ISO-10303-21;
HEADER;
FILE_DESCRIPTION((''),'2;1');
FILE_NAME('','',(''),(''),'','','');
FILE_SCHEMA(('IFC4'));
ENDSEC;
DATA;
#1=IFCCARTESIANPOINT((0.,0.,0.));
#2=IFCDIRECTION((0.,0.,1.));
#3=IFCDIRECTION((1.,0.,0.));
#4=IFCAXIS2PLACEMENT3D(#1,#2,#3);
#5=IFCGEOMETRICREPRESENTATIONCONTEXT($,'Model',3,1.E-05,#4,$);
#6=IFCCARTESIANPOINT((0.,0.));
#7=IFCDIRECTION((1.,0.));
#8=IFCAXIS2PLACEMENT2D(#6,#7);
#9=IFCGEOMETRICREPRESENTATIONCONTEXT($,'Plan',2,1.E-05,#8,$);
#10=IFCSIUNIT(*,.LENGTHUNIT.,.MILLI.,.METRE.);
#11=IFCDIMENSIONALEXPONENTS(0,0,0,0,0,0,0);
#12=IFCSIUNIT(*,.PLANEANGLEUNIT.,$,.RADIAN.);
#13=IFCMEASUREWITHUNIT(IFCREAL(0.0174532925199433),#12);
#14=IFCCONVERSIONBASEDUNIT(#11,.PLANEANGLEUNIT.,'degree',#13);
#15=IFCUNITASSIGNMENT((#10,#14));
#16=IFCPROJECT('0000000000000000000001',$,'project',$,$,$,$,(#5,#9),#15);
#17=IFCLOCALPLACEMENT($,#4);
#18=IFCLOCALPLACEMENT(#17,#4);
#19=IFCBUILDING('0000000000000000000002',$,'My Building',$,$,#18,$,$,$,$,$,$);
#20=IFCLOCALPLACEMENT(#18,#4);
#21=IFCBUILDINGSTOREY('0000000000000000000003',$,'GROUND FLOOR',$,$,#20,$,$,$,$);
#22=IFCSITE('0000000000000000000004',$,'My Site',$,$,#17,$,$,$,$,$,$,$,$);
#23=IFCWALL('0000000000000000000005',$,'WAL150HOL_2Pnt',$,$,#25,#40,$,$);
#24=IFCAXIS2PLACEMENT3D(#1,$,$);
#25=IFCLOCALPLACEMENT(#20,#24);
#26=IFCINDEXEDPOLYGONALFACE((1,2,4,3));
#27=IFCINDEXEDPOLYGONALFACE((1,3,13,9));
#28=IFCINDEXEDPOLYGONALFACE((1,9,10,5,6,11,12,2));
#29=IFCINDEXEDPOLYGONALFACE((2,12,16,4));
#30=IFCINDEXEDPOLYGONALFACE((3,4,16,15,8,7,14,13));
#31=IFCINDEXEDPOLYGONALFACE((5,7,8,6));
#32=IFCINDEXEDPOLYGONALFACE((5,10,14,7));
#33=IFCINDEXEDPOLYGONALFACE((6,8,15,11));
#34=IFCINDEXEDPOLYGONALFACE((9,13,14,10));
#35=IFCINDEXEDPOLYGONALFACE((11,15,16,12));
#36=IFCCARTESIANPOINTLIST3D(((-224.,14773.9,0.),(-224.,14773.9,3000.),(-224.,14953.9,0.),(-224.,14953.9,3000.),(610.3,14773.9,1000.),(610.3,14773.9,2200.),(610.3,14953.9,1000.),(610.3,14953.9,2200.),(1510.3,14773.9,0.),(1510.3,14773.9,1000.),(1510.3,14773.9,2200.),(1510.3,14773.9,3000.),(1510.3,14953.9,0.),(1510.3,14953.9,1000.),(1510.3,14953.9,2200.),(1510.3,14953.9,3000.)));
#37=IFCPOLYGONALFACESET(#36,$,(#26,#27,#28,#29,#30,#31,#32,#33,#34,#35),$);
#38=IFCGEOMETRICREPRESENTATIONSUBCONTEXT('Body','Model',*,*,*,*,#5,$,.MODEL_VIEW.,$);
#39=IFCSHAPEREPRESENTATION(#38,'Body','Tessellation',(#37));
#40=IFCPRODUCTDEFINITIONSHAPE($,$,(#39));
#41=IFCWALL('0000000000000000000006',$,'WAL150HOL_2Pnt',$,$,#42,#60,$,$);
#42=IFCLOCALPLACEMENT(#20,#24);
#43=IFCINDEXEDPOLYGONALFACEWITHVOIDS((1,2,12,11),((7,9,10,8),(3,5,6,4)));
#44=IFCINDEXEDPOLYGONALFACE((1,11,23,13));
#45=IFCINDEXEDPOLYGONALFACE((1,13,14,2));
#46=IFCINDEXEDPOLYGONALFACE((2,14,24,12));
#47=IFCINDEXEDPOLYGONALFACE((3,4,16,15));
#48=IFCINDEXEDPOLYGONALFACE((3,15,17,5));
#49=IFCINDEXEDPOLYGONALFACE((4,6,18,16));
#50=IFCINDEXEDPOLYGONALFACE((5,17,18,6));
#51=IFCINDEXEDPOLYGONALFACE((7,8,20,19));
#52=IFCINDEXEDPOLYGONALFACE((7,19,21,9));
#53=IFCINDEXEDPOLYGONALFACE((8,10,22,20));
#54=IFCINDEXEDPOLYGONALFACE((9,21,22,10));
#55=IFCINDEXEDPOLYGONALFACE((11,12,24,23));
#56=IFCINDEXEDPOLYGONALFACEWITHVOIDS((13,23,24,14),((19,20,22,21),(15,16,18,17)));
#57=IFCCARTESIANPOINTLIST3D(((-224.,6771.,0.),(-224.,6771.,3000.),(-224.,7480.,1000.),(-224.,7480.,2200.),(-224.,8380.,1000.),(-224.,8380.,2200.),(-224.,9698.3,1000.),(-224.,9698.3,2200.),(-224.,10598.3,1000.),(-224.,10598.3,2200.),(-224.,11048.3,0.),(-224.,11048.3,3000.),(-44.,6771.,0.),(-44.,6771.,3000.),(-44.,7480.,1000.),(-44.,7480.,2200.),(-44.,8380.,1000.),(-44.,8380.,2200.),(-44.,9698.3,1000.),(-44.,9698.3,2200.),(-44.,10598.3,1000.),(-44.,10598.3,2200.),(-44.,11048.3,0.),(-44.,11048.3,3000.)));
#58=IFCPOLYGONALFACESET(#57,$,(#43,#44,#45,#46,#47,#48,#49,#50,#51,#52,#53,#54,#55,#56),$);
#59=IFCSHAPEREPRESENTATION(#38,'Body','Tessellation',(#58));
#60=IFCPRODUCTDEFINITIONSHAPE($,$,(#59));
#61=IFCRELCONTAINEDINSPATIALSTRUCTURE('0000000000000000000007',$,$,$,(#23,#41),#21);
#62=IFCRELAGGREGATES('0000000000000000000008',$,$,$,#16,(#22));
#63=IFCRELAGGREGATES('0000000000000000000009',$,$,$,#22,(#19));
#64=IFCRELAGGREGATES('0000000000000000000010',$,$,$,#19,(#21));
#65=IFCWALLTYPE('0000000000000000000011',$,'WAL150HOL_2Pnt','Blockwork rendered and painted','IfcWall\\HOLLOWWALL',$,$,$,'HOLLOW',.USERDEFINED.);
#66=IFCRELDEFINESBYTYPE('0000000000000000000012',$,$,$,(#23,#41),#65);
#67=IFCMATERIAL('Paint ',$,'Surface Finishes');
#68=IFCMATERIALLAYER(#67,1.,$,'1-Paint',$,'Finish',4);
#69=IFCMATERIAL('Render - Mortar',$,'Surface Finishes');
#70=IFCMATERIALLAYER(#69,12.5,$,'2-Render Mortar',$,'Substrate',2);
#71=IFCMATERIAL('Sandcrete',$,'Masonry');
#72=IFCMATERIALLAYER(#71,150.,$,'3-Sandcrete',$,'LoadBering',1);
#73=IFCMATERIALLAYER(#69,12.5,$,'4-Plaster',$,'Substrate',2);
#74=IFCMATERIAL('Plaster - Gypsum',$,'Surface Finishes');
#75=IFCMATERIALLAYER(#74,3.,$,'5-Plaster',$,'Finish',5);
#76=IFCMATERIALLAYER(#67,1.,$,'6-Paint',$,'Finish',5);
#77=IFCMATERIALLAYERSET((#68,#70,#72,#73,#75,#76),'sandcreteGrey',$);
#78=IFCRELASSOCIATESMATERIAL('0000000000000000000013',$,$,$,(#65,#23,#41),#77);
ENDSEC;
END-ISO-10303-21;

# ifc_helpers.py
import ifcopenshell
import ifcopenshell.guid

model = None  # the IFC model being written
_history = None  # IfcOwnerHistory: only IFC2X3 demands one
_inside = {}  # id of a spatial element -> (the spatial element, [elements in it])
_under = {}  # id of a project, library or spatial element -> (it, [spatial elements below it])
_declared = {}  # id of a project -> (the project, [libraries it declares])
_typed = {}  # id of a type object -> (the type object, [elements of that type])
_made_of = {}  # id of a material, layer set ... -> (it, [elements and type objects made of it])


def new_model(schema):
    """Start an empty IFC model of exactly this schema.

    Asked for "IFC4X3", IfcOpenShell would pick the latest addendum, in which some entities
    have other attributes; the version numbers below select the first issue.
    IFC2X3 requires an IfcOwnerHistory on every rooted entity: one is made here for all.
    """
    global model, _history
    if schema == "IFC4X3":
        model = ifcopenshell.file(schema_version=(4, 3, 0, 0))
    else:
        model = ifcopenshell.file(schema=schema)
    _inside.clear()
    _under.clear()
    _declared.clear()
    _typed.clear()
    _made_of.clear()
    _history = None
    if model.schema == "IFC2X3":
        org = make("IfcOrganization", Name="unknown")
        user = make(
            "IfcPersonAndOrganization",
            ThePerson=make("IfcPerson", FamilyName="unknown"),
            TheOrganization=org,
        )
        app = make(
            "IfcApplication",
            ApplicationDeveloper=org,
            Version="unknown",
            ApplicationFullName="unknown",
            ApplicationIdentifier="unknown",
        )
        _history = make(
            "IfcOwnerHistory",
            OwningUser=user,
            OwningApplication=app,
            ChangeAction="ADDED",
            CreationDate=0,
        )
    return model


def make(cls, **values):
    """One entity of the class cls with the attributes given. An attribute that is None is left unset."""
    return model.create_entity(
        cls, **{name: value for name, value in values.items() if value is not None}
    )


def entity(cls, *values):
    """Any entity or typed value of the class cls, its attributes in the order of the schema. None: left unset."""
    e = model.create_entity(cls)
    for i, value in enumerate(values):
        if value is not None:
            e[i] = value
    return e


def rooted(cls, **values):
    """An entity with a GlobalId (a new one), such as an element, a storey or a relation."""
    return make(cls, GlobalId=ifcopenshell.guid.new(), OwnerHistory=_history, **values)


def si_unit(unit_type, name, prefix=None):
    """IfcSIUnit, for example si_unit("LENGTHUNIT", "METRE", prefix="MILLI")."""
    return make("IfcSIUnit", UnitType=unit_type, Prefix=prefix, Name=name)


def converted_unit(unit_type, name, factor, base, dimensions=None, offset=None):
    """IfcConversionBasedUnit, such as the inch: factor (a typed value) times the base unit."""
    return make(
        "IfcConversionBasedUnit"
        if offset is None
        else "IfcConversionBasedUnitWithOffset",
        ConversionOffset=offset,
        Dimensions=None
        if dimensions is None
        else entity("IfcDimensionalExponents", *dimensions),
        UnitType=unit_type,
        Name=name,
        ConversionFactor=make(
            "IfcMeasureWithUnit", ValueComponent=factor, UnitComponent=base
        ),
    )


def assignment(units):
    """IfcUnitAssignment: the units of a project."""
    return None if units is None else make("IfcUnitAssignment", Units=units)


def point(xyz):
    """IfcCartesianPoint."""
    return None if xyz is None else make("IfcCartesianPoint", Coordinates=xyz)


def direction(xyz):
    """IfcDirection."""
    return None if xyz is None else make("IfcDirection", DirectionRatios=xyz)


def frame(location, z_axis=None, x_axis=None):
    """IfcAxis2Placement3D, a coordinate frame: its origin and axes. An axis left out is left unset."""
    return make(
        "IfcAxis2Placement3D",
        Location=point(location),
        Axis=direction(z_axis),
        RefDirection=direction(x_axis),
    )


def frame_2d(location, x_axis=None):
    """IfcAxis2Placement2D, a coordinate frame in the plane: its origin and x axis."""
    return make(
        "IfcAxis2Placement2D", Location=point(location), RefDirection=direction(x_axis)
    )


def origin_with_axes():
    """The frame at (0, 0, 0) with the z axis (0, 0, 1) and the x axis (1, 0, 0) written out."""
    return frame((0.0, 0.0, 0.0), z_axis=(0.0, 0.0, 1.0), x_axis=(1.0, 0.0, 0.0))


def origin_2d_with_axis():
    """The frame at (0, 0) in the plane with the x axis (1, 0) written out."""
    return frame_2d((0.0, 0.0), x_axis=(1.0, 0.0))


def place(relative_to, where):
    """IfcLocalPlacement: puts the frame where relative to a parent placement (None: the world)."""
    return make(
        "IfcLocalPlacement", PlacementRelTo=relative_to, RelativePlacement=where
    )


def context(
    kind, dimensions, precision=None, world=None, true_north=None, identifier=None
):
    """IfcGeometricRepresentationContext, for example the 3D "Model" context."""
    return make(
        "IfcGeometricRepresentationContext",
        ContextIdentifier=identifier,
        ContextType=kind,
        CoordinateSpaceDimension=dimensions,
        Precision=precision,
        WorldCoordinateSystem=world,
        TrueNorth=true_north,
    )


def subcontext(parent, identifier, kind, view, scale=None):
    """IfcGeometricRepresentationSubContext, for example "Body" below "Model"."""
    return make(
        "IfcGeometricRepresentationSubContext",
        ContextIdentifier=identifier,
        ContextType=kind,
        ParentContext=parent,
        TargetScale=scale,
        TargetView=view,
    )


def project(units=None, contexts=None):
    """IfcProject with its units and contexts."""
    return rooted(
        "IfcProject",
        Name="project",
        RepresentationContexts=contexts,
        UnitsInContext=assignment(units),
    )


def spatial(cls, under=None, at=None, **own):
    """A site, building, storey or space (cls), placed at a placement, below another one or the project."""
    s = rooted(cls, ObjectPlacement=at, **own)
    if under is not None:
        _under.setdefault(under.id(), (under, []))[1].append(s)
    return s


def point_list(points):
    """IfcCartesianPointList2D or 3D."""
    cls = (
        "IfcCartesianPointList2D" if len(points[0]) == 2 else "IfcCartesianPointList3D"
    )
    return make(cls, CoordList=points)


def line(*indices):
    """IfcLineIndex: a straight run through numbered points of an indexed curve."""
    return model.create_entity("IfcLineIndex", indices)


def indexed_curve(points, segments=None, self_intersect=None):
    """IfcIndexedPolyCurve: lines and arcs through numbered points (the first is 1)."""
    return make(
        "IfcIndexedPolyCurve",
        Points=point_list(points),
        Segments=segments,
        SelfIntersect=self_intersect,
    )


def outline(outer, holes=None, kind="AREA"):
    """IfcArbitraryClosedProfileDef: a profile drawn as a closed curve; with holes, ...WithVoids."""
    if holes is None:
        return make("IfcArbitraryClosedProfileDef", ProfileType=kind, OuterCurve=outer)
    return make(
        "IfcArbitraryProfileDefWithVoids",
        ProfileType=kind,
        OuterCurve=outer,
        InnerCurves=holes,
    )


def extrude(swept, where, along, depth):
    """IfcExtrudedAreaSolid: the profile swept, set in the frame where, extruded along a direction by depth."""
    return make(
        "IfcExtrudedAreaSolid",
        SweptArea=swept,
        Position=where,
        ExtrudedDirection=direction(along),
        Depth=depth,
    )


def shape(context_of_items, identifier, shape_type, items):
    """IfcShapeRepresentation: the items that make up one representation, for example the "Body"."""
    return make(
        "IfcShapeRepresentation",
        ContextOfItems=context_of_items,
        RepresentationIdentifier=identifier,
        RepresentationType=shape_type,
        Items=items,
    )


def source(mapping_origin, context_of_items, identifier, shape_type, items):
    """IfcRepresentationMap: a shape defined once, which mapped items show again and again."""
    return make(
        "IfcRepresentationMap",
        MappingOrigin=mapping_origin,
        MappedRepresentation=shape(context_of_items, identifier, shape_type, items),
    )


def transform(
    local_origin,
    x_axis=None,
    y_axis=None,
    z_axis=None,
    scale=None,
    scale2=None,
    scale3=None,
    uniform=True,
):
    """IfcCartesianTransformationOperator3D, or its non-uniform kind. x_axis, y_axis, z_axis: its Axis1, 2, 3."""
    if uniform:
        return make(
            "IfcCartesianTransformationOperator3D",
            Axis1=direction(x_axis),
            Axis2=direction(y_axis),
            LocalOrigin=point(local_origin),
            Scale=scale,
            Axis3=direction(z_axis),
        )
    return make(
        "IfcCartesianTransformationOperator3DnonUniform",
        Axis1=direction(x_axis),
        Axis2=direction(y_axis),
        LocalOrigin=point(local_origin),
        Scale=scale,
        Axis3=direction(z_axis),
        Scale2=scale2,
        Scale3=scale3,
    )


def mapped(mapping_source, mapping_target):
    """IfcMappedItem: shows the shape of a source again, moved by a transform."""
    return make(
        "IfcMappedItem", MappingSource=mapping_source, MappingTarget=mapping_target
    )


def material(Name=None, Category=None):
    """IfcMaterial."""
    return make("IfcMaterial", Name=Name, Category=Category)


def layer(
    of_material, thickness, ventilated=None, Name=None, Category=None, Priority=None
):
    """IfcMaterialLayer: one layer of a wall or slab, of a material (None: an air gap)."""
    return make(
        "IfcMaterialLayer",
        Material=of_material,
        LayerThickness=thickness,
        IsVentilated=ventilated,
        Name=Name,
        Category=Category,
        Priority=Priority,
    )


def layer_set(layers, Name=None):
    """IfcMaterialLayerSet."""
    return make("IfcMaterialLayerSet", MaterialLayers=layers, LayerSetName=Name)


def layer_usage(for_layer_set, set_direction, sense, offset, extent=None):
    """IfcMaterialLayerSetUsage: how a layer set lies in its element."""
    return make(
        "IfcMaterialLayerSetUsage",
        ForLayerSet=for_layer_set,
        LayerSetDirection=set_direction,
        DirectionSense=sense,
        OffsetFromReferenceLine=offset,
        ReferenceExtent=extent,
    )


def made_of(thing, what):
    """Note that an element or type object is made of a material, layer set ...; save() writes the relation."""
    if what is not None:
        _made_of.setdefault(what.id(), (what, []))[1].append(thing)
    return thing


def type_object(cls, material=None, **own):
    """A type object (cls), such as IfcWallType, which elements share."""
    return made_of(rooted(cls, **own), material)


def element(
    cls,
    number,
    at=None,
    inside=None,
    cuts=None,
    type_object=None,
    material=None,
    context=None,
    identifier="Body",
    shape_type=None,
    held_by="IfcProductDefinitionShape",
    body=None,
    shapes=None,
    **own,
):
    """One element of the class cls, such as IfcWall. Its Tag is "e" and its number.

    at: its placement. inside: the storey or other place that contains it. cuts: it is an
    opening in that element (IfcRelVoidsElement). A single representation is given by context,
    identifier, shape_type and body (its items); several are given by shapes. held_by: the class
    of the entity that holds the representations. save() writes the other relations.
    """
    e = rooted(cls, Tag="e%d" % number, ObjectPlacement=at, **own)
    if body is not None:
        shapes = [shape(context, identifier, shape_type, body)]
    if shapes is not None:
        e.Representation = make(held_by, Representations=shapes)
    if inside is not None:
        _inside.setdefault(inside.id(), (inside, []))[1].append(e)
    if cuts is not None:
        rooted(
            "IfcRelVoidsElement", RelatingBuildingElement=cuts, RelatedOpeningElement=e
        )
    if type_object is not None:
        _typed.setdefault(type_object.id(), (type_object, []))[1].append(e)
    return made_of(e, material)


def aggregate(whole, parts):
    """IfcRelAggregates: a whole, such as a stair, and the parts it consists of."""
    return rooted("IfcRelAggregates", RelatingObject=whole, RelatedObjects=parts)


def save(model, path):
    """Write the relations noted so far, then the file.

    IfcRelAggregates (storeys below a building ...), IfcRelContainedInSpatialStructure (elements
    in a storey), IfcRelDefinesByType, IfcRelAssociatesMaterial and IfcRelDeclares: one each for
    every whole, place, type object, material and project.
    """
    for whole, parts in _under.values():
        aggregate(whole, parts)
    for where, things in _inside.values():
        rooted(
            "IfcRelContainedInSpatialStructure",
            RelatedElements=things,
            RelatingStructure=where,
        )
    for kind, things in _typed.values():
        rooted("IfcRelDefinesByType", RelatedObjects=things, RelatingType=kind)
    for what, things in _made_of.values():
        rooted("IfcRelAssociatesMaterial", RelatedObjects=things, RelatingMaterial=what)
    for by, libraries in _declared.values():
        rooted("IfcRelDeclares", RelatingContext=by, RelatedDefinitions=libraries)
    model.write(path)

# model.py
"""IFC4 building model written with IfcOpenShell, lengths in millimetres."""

from ifc_helpers import new_model, entity, si_unit, converted_unit, frame, origin_with_axes, origin_2d_with_axis, place, context, subcontext, project, spatial, line, indexed_curve, outline, extrude, source, transform, mapped, material, layer, layer_set, layer_usage, type_object, element, save


model = new_model("IFC4")

# Units and contexts
model_context = context("Model", 3, precision=1e-05, world=origin_with_axes())
plan_context = context("Plan", 2, precision=1e-05, world=origin_2d_with_axis())
body_context_1 = subcontext(model_context, "Body", "Model", "MODEL_VIEW")
ifc_project = project(units=[si_unit("LENGTHUNIT", "METRE", prefix="MILLI"), converted_unit("PLANEANGLEUNIT", "degree", entity("IfcReal", 0.0174532925199433), si_unit("PLANEANGLEUNIT", "RADIAN"), dimensions=[0, 0, 0, 0, 0, 0, 0])], contexts=[model_context, plan_context])

# Site, building, storey
site_placement = place(None, origin_with_axes())
site = spatial("IfcSite", under=ifc_project, at=site_placement, Name="My Site")
building_placement = place(site_placement, origin_with_axes())
building = spatial("IfcBuilding", under=site, at=building_placement, Name="My Building")
storey_placement = place(building_placement, origin_with_axes())
storey = spatial("IfcBuildingStorey", under=building, at=storey_placement, Name="GROUND FLOOR")

# Shared definitions
ifc_material_1 = material(Name="Paint ", Category="Surface Finishes")
ifc_layer_1 = layer(ifc_material_1, 1.0, Name="1-Paint", Category="Finish", Priority=4)
ifc_material_2 = material(Name="Render - Mortar", Category="Surface Finishes")
ifc_layer_2 = layer(ifc_material_2, 12.5, Name="2-Render Mortar", Category="Substrate", Priority=2)
ifc_material_3 = material(Name="Sandcrete", Category="Masonry")
ifc_layer_3 = layer(ifc_material_3, 150.0, Name="3-Sandcrete", Category="LoadBering", Priority=1)
ifc_layer_4 = layer(ifc_material_2, 12.5, Name="4-Plaster", Category="Substrate", Priority=2)
ifc_material_4 = material(Name="Plaster - Gypsum", Category="Surface Finishes")
ifc_layer_5 = layer(ifc_material_4, 3.0, Name="5-Plaster", Category="Finish", Priority=5)
ifc_layer_6 = layer(ifc_material_1, 1.0, Name="6-Paint", Category="Finish", Priority=5)
ifc_layer_set_1 = layer_set([ifc_layer_1, ifc_layer_2, ifc_layer_3, ifc_layer_4, ifc_layer_5, ifc_layer_6], Name="sandcreteGrey")
wall_type_1 = type_object("IfcWallType", Name="WAL150HOL_2Pnt", Description="Blockwork rendered and painted", ApplicableOccurrence="IfcWall\\HOLLOWWALL", ElementType="HOLLOW", PredefinedType="USERDEFINED", material=ifc_layer_set_1)

# Wall, opening
ifc_layer_usage_1 = layer_usage(ifc_layer_set_1, "AXIS2", "POSITIVE", 0.0)
wall_1_placement = place(storey_placement, frame((1510.3, 14953.9, 0.0), z_axis=(0.0, 0.0, 1.0), x_axis=(-1.0, 0.0, 0.0)))
wall_1 = element("IfcWall", 1, at=wall_1_placement, inside=storey, type_object=wall_type_1, material=ifc_layer_usage_1, Name="WAL150HOL_2Pnt", context=body_context_1, shape_type="SweptSolid", body=[
    extrude(outline(indexed_curve([(0.0, 0.0), (0.0, 180.0), (1734.3, 180.0), (1734.3, 0.0), (0.0, 0.0)], self_intersect=False)), origin_with_axes(), (0.0, 0.0, 1.0), 3000.0),
])
shared_shape_1 = source(origin_with_axes(), body_context_1, "Body", "SweptSolid", [
    extrude(outline(indexed_curve([(0.0, 0.0), (900.0, 0.0), (900.0, 1200.0), (0.0, 1200.0)], segments=[line(1, 2, 3, 4, 1)])), frame((0.0, -600.0, 0.0), z_axis=(0.0, -1.0, 0.0), x_axis=(1.0, 0.0, 0.0)), (0.0, 0.0, -1.0), 1200.0),
])
opening_1_placement = place(wall_1_placement, frame((0.0, 0.0, 1000.0), z_axis=(0.0, 0.0, 1.0), x_axis=(1.0, 0.0, 0.0)))
element("IfcOpeningElement", 2, at=opening_1_placement, cuts=wall_1, PredefinedType="OPENING", context=body_context_1, shape_type="MappedRepresentation", body=[
    mapped(shared_shape_1, transform((0.0, 0.0, 0.0), x_axis=(1.0, 0.0, 0.0), y_axis=(0.0, 1.0, 0.0), z_axis=(0.0, 0.0, 1.0), scale=1.0)),
])

# Wall, openings
ifc_layer_usage_2 = layer_usage(ifc_layer_set_1, "AXIS2", "POSITIVE", 0.0)
wall_2_placement = place(storey_placement, frame((-224.0, 11048.3, 0.0), z_axis=(0.0, 0.0, 1.0), x_axis=(0.0, -1.0, 0.0)))
wall_2 = element("IfcWall", 3, at=wall_2_placement, inside=storey, type_object=wall_type_1, material=ifc_layer_usage_2, Name="WAL150HOL_2Pnt", context=body_context_1, shape_type="SweptSolid", body=[
    extrude(outline(indexed_curve([(0.0, 0.0), (0.0, 180.0), (4277.3, 180.0), (4277.3, 0.0), (0.0, 0.0)], self_intersect=False)), origin_with_axes(), (0.0, 0.0, 1.0), 3000.0),
])
opening_2_placement = place(wall_2_placement, frame((450.0, 0.0, 1000.0), z_axis=(0.0, 0.0, 1.0), x_axis=(1.0, 0.0, 0.0)))
element("IfcOpeningElement", 4, at=opening_2_placement, cuts=wall_2, PredefinedType="OPENING", context=body_context_1, shape_type="MappedRepresentation", body=[
    mapped(shared_shape_1, transform((0.0, 0.0, 0.0), x_axis=(1.0, 0.0, 0.0), y_axis=(0.0, 1.0, 0.0), z_axis=(0.0, 0.0, 1.0), scale=1.0)),
])
opening_3_placement = place(wall_2_placement, frame((2668.3, 0.0, 1000.0), z_axis=(0.0, 0.0, 1.0), x_axis=(1.0, 0.0, 0.0)))
element("IfcOpeningElement", 5, at=opening_3_placement, cuts=wall_2, PredefinedType="OPENING", context=body_context_1, shape_type="MappedRepresentation", body=[
    mapped(shared_shape_1, transform((0.0, 0.0, 0.0), x_axis=(1.0, 0.0, 0.0), y_axis=(0.0, 1.0, 0.0), z_axis=(0.0, 0.0, 1.0), scale=1.0)),
])

save(model, "model.ifc")
